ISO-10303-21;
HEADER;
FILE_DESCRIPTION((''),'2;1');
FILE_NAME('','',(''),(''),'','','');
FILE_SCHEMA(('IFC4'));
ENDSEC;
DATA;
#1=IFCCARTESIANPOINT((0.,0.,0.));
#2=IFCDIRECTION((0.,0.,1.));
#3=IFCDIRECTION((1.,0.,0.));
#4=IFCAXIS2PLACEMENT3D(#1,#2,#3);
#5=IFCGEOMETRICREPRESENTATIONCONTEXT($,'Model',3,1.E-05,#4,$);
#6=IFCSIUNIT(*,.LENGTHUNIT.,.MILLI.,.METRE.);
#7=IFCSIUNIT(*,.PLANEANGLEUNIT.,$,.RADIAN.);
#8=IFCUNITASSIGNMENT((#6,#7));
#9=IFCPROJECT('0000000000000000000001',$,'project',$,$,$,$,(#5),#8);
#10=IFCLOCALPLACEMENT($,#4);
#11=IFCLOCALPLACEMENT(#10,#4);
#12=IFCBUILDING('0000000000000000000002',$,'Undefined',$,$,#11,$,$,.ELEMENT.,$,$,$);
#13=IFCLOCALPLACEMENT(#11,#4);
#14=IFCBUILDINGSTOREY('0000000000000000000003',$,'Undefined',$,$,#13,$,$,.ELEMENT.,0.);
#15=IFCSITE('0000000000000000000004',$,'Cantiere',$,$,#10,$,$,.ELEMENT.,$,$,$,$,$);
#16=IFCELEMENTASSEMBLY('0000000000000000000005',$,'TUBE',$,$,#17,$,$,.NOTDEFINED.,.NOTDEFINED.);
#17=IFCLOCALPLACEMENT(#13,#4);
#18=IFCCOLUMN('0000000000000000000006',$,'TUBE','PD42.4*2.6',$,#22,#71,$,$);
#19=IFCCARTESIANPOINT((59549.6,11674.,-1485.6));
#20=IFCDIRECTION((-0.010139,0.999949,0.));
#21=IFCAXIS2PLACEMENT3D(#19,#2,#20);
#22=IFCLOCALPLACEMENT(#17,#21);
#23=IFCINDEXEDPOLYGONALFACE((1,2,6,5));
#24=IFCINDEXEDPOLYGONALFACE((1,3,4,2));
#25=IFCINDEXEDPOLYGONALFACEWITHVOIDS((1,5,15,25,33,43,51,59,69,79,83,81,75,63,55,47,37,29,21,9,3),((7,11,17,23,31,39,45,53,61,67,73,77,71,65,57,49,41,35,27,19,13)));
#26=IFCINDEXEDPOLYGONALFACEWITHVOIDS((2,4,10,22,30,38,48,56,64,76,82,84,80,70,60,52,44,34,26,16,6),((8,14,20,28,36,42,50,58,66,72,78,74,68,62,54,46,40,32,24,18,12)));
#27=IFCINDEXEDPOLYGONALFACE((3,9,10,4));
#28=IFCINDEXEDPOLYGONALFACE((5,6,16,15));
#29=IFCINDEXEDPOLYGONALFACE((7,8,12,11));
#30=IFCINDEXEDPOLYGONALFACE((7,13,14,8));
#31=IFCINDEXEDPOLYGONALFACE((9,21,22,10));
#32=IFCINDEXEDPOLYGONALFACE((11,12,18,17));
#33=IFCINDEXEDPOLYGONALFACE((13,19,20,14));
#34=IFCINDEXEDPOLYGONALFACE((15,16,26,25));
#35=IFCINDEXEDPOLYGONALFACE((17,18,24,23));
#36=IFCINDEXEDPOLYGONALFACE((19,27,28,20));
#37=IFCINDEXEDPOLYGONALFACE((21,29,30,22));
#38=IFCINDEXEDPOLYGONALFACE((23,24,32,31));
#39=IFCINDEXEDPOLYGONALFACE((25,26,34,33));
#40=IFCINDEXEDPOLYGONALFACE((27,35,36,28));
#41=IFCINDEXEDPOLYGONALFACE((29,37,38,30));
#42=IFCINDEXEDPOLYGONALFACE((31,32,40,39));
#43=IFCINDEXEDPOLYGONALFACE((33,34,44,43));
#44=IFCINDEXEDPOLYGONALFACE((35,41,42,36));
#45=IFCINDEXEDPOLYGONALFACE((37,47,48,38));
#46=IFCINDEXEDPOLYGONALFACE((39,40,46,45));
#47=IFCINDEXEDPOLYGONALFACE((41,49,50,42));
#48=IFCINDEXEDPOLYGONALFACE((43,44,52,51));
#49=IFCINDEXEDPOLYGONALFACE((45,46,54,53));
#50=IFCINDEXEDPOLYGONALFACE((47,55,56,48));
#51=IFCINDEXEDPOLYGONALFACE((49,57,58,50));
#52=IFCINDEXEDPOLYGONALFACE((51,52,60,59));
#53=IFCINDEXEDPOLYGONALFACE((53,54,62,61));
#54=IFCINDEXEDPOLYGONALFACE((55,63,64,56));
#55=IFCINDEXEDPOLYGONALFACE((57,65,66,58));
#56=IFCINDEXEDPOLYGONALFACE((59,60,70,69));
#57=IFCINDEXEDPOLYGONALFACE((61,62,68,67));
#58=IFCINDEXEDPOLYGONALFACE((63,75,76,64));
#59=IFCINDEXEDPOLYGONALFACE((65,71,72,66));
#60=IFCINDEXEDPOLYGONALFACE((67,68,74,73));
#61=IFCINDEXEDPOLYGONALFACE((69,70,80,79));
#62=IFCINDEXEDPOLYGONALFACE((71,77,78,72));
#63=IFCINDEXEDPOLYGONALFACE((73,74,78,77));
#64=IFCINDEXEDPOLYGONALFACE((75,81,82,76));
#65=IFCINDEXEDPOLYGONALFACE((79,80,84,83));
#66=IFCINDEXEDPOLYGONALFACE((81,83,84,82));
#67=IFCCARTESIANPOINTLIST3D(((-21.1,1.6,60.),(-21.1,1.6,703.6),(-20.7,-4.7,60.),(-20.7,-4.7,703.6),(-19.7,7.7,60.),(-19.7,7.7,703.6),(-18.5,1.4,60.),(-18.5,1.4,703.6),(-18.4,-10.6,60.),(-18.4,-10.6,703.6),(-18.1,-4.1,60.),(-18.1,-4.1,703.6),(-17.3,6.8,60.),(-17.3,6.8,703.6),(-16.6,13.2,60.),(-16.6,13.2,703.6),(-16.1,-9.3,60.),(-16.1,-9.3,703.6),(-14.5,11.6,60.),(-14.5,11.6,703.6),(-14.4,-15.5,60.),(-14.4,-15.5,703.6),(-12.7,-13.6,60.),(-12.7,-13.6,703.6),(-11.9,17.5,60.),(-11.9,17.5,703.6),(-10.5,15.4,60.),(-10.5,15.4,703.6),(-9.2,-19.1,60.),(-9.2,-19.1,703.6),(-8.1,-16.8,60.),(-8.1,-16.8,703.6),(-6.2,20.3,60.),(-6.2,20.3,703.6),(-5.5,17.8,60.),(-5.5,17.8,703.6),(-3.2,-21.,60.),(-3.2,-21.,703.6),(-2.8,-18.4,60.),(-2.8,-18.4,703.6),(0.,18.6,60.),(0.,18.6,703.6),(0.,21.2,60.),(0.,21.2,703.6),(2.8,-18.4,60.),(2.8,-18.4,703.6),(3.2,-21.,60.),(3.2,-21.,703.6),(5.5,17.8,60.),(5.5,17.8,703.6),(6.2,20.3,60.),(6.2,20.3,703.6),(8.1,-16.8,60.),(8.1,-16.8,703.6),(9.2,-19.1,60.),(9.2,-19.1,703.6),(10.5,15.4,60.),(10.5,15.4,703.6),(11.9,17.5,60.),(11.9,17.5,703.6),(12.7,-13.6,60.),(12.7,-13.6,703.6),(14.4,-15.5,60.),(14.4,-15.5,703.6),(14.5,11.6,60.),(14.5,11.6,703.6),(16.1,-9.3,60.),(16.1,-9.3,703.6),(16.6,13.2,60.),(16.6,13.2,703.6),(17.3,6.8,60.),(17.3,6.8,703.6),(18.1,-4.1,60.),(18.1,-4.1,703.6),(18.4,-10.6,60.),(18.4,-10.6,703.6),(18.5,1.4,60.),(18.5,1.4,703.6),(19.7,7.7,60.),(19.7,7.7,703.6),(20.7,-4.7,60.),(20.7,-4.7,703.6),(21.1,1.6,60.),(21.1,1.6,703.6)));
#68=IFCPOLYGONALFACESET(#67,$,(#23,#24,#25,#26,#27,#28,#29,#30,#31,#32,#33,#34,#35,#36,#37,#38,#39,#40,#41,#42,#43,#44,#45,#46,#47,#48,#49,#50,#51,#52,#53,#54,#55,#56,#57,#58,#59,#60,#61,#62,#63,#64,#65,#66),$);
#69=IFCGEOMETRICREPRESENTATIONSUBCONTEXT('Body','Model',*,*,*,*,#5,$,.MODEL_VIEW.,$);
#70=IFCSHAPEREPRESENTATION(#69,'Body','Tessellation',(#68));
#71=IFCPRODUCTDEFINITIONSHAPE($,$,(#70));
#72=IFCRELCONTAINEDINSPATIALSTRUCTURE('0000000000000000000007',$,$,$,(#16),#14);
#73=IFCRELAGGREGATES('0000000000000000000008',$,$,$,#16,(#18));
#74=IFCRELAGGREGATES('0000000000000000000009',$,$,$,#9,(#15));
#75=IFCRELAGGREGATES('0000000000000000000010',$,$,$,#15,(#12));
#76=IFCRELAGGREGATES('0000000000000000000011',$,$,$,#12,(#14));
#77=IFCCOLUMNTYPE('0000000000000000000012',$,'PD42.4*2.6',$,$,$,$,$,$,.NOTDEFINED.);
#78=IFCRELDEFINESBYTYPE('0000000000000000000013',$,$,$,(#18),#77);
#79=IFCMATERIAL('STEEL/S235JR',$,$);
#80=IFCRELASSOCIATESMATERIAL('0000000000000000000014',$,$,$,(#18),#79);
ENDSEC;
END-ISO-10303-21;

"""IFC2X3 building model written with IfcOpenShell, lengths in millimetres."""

from ifc_helpers import new_model, si_unit, frame, origin_with_axes, origin_2d_with_axis, place, context, subcontext, project, spatial, hollow_circle, extrude, clip, halfspace, material, type_object, element, aggregate, save


model = new_model("IFC2X3")

# Units and contexts
model_context = context("Model", 3, precision=1e-05, world=origin_with_axes())
body_context = subcontext(model_context, "Body", "Model", "MODEL_VIEW")
ifc_project = project(units=[si_unit("LENGTHUNIT", "METRE", prefix="MILLI"), si_unit("PLANEANGLEUNIT", "RADIAN")], contexts=[model_context])

# Site, building, storey
site_placement = place(None, origin_with_axes())
site = spatial("IfcSite", under=ifc_project, at=site_placement, Name="Cantiere", CompositionType="ELEMENT")
building_placement = place(site_placement, origin_with_axes())
building = spatial("IfcBuilding", under=site, at=building_placement, Name="Undefined", CompositionType="ELEMENT")
storey_placement = place(building_placement, origin_with_axes())
storey = spatial("IfcBuildingStorey", under=building, at=storey_placement, Name="Undefined", CompositionType="ELEMENT", Elevation=0.0)

# Element assembly, column
assembly_1_placement = place(storey_placement, origin_with_axes())
assembly_1 = element("IfcElementAssembly", 1, at=assembly_1_placement, inside=storey, Name="TUBE", AssemblyPlace="NOTDEFINED", PredefinedType="NOTDEFINED")
ifc_material_1 = material(Name="STEEL/S235JR")
column_type = type_object("IfcColumnType", Name="PD42.4*2.6", PredefinedType="NOTDEFINED")
column_placement = place(assembly_1_placement, frame((59549.6, 11674.0, -1485.6), z_axis=(0.0, 0.0, 1.0), x_axis=(-0.010139, 0.999949, 0.0)))
column = element("IfcColumn", 2, at=column_placement, type_object=column_type, material=ifc_material_1, Name="TUBE", Description="PD42.4*2.6", context=body_context, shape_type="Clipping", body=[
    clip(clip(extrude(hollow_circle(Radius=21.2, WallThickness=2.6, at=origin_2d_with_axis()), frame((0.0, 0.0, 753.6), z_axis=(0.0, 0.000001, -1.0), x_axis=(0.0, 1.0, 0.0)), (0.0, 0.0, 1.0), 753.6), halfspace(frame((0.0, 0.0, 703.6), z_axis=(0.0, 0.0, 1.0), x_axis=(-1.0, 0.0, 0.0)), False)), halfspace(frame((0.0, 0.0, 60.0), z_axis=(0.0, 0.000001, -1.0), x_axis=(-1.0, 0.0, 0.0)), False)),
])

aggregate(assembly_1, [column])

save(model, "model.ifc")
